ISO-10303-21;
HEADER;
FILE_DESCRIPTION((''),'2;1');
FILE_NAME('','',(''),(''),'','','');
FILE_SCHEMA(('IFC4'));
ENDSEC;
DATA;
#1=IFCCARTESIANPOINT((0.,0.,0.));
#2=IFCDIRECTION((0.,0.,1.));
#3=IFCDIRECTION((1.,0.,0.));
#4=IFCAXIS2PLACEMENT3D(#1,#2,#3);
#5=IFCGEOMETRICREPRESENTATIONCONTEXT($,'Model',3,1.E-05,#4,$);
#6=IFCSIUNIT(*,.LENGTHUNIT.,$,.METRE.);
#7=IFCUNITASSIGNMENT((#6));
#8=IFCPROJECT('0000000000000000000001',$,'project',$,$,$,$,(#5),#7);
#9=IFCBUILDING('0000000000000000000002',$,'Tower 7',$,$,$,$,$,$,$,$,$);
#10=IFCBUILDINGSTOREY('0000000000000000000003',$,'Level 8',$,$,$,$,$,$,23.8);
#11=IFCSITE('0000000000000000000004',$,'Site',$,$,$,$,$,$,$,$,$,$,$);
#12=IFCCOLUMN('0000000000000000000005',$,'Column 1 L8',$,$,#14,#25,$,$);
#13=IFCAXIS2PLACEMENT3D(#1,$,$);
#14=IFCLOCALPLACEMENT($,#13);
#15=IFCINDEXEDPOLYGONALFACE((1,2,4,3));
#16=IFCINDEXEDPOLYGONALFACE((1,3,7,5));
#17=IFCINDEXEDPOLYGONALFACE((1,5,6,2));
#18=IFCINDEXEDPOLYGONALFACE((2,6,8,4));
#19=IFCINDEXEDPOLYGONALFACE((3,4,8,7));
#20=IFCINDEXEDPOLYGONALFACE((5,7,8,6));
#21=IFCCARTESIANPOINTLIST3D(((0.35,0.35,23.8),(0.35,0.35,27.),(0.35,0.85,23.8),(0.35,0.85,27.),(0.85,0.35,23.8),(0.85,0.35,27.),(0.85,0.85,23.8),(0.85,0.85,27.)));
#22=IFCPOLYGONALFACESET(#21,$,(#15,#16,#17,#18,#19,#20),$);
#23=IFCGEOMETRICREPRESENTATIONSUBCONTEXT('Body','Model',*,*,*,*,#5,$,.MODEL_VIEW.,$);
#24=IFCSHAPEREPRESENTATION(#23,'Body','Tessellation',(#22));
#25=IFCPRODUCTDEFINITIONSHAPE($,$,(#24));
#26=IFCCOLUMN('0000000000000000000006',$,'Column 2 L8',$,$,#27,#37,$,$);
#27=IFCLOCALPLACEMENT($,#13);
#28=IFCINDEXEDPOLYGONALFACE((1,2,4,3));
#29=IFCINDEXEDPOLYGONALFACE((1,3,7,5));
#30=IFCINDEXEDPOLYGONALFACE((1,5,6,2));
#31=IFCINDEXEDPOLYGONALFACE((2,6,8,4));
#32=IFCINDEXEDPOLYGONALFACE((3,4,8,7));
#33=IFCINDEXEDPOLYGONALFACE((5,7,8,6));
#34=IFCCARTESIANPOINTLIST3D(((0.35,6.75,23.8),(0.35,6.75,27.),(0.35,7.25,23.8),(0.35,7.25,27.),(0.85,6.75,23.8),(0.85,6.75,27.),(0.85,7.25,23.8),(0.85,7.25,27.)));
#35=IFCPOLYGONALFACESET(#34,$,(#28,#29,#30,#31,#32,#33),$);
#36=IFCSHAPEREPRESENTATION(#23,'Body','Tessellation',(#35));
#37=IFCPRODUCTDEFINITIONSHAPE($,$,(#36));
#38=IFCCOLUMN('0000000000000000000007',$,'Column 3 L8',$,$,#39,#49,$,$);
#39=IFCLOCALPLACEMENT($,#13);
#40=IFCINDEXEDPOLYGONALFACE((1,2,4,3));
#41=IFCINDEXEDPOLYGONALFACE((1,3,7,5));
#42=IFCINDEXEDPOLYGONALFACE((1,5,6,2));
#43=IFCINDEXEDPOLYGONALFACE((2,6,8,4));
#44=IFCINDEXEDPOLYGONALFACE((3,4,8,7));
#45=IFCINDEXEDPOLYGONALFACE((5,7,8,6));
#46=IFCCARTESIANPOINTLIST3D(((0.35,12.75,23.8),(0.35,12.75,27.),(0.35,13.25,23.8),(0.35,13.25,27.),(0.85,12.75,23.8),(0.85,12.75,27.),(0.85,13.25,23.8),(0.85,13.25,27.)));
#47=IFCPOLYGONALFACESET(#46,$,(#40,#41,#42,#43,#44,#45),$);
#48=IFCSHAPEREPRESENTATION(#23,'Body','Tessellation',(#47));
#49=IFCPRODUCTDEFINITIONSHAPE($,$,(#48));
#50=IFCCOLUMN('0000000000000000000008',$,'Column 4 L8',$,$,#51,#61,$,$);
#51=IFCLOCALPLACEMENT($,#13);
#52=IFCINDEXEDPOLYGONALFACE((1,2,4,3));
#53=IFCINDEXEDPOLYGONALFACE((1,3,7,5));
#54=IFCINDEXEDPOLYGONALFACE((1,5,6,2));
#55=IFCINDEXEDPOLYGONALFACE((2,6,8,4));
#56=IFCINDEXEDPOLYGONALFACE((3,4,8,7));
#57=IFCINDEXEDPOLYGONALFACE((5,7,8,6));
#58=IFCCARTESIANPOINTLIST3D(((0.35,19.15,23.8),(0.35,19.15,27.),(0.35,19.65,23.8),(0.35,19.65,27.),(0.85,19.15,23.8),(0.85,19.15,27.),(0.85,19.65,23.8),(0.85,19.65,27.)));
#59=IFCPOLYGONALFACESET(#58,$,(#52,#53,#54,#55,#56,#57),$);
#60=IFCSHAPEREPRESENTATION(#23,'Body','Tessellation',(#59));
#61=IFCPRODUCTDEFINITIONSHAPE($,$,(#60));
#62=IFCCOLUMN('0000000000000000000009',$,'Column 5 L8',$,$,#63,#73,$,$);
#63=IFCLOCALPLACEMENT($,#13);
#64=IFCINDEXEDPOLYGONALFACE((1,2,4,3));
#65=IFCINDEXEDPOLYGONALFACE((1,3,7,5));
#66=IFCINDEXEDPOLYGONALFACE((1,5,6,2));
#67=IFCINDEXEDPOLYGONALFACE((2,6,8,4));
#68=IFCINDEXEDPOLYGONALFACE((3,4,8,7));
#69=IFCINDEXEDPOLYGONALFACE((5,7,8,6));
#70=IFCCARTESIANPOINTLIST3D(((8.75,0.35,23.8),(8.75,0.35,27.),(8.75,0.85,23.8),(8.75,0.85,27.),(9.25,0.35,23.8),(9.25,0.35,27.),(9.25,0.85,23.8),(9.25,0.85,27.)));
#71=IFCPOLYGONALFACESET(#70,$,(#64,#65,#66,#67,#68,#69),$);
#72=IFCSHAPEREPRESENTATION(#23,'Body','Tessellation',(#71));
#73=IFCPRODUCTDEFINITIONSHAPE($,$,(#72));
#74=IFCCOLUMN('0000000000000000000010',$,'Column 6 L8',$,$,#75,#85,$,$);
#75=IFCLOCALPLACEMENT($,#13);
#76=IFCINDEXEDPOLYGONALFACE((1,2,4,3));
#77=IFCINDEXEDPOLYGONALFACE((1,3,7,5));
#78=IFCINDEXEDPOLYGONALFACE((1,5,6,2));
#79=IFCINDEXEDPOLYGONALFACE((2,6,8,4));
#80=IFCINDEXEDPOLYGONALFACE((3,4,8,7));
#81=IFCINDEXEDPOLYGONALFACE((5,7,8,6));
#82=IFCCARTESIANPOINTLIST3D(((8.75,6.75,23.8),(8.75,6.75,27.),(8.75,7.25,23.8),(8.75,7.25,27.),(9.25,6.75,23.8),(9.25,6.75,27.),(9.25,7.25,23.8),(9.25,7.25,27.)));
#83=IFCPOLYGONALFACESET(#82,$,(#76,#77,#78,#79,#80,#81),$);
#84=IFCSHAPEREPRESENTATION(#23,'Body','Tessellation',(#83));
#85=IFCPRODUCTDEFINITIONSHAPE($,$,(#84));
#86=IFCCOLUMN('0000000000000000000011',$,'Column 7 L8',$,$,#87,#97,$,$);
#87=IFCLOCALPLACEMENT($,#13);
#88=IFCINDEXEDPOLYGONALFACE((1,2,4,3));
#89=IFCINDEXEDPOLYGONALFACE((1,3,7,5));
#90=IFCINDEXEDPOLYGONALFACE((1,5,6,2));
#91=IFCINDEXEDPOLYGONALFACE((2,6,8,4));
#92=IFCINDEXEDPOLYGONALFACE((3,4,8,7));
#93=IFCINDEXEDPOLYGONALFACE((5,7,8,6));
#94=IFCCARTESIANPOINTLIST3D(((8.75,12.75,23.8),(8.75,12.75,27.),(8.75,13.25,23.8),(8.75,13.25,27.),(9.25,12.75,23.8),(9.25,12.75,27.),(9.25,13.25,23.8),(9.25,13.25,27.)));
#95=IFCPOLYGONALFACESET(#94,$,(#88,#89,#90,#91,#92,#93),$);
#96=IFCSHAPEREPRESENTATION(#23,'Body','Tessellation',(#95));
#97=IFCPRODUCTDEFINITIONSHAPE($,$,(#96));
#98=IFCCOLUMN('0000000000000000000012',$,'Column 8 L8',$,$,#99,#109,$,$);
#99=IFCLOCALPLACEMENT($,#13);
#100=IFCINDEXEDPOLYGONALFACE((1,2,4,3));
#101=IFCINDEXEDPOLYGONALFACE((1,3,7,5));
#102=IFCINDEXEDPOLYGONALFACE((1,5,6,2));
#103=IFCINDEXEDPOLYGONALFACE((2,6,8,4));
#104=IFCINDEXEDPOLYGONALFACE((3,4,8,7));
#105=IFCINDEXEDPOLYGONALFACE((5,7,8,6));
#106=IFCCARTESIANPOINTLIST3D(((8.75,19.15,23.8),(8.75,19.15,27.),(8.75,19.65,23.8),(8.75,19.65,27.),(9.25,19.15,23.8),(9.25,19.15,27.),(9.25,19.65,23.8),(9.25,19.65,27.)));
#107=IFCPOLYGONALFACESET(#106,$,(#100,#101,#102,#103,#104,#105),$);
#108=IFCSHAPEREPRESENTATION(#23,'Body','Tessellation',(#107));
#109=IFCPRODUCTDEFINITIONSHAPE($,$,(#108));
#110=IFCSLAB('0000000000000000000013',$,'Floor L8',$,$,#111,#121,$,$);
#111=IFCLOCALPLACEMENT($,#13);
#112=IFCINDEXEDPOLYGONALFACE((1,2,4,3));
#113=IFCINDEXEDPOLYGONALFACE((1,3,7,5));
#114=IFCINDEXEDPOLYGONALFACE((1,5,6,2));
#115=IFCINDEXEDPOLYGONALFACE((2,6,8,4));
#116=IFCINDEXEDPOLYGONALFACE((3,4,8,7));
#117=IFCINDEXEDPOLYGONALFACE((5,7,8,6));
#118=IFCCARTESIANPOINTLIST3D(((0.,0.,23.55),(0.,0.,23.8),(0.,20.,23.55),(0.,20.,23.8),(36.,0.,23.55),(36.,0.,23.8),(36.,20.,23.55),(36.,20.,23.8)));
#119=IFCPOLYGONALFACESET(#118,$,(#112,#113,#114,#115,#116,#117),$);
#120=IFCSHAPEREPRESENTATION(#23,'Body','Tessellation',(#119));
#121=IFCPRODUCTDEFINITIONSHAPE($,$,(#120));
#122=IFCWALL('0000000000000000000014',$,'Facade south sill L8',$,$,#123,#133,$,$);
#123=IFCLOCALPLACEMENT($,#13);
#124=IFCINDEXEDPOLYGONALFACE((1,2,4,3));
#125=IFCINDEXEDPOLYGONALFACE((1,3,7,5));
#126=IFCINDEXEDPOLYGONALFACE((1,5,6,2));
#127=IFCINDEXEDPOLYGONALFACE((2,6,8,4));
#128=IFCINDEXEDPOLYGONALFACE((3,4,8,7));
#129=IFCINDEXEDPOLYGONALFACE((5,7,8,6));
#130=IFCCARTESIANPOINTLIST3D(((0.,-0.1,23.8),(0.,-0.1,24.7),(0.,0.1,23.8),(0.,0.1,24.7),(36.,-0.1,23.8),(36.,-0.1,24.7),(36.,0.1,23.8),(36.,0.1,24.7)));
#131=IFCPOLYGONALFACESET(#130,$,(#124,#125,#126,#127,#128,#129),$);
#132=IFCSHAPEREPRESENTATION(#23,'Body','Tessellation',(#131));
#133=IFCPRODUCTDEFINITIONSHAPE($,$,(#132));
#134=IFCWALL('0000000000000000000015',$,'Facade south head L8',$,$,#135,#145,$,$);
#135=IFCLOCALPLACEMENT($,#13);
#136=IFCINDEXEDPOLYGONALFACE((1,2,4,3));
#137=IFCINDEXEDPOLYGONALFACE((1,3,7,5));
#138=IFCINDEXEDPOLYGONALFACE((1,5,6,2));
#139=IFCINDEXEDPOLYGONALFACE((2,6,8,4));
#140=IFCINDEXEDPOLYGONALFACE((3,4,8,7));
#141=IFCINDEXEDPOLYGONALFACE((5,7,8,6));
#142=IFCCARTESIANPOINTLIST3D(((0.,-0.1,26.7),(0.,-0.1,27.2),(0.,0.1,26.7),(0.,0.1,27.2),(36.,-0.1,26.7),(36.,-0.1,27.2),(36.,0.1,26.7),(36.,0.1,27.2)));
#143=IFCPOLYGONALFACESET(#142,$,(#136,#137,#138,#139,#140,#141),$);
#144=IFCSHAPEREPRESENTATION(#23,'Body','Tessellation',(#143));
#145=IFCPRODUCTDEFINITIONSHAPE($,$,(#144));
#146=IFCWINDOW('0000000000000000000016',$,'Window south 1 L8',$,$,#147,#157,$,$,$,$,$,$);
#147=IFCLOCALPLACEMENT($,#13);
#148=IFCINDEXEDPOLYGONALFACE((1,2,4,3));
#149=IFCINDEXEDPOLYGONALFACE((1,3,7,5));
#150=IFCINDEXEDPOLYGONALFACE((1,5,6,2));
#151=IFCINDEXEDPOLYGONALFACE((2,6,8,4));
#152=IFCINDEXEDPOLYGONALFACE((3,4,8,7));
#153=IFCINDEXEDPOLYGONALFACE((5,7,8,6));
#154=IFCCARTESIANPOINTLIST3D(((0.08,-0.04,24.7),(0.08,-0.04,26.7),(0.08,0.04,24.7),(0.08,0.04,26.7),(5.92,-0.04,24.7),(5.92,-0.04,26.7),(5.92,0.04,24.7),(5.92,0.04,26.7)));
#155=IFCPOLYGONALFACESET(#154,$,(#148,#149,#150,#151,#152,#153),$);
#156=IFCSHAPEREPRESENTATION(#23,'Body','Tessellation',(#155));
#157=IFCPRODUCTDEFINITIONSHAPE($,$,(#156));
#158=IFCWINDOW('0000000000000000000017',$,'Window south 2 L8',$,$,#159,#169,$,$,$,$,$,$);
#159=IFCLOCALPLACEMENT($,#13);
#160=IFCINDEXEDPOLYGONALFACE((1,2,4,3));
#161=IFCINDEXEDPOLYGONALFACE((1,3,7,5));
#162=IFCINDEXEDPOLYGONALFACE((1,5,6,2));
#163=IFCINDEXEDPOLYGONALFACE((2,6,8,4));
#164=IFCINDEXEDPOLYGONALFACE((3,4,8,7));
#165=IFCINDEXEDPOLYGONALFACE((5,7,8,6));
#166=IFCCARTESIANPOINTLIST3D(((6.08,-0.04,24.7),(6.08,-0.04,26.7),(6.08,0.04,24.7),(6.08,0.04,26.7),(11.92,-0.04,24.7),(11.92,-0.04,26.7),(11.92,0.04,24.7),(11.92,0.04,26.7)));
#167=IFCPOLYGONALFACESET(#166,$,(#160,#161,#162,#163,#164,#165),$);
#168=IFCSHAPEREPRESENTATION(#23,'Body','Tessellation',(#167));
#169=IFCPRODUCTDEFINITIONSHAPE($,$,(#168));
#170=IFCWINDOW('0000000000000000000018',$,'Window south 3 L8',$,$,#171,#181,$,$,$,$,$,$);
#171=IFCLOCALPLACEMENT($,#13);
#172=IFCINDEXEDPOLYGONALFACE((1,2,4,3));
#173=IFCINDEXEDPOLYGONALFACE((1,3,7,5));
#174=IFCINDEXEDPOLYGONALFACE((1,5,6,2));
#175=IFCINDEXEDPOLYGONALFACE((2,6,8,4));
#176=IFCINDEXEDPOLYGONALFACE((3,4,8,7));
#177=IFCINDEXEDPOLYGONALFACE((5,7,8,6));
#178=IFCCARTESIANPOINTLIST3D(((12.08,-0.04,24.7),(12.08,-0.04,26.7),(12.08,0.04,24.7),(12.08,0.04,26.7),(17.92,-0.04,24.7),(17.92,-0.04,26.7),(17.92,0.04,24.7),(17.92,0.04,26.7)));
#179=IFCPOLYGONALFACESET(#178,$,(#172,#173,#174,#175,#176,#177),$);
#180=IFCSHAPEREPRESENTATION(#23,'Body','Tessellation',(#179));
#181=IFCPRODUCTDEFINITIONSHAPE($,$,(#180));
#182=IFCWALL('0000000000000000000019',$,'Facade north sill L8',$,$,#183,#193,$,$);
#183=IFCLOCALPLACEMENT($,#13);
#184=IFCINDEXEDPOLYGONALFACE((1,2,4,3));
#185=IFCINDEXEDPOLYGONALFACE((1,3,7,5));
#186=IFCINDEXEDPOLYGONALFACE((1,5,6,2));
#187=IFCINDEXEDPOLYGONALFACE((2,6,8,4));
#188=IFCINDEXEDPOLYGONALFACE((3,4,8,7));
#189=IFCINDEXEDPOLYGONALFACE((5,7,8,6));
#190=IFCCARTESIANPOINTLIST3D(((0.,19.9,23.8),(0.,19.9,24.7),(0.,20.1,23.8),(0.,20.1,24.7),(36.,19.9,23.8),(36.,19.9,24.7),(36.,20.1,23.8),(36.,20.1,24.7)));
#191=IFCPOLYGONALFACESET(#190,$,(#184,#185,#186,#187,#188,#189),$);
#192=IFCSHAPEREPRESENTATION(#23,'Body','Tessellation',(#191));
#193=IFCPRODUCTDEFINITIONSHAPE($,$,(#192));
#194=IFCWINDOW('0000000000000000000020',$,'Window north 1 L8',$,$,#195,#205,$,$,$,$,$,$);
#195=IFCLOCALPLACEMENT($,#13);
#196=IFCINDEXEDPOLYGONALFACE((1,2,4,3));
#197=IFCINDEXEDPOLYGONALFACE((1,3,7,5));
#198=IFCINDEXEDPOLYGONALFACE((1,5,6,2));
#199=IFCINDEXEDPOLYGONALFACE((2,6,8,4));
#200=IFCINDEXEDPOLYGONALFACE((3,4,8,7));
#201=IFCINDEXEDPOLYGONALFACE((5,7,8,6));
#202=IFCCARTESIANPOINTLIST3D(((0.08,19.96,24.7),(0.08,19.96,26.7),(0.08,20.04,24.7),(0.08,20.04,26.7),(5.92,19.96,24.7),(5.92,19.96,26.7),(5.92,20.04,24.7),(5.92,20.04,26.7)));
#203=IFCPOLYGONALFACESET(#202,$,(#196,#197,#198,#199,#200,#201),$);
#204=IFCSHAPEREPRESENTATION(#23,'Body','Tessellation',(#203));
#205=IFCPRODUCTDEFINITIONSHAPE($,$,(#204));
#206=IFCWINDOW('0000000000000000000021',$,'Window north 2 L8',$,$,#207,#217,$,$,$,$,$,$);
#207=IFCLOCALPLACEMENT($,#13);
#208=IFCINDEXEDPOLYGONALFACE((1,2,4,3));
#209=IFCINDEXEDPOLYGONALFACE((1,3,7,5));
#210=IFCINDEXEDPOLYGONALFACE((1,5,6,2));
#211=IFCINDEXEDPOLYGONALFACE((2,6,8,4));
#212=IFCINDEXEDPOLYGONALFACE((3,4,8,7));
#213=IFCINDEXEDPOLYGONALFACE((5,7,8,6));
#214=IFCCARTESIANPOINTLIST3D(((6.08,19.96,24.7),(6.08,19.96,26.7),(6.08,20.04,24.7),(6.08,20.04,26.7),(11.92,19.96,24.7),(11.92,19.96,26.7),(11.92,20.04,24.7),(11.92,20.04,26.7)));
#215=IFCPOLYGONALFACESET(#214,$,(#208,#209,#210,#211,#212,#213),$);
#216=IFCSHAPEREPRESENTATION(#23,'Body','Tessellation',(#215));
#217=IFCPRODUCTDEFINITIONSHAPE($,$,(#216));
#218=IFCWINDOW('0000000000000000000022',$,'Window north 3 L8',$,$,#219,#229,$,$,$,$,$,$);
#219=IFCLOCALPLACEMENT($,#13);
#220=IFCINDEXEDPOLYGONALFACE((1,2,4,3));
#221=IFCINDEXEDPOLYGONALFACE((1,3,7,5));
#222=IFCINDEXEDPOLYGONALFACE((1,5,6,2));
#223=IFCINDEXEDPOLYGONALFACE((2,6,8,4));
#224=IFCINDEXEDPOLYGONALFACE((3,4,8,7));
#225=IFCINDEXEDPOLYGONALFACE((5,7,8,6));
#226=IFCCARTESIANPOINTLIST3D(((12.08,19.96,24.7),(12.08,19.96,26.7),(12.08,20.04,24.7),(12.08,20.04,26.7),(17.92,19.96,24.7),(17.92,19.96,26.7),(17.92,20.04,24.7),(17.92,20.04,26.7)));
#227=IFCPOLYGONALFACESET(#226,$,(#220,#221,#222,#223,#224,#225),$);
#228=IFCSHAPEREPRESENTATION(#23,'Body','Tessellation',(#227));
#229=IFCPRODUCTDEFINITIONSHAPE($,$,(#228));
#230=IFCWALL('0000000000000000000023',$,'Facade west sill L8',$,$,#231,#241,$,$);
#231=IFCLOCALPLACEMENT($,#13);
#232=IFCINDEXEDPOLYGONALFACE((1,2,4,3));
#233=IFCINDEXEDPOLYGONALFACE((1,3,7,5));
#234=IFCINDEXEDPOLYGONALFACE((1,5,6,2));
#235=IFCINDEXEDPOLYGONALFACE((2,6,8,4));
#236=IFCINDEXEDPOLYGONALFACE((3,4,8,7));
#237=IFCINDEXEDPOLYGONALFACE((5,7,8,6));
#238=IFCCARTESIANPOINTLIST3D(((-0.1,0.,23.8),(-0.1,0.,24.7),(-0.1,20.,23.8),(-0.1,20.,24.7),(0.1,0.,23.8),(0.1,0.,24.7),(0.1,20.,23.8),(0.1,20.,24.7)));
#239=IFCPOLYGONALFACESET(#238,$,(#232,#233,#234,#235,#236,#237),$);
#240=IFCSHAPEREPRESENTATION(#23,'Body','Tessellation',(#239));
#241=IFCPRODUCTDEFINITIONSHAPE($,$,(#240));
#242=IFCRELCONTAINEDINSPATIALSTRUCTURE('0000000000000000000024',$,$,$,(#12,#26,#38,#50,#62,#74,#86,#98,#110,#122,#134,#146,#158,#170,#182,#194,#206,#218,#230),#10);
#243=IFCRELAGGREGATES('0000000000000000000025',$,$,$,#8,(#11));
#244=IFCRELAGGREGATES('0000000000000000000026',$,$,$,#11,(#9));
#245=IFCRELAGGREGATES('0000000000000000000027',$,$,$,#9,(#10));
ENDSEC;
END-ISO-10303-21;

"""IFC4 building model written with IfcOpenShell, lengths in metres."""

from ifc_helpers import new_model, si_unit, frame, origin, origin_with_axes, origin_2d, place, context, subcontext, project, spatial, rectangle, extrude, element, save


model = new_model("IFC4")

# Units and contexts
model_context = context("Model", 3, precision=1e-05, world=origin_with_axes())
body_context = subcontext(model_context, "Body", "Model", "MODEL_VIEW")
ifc_project = project(units=[si_unit("LENGTHUNIT", "METRE")], contexts=[model_context])

# Site, building, storey
site = spatial("IfcSite", under=ifc_project, Name="Site")
building = spatial("IfcBuilding", under=site, Name="Tower 7")
storey = spatial("IfcBuildingStorey", under=building, Name="Level 8", Elevation=23.8)

# Columns
for number, where, z_axis, x_axis, name in (
    (1, (0.6, 0.6, 23.8), (0.0, 0.0, 1.0), (1.0, 0.0, 0.0), "Column 1 L8"),
    (2, (0.6, 7.0, 23.8), (0.0, 0.0, 1.0), (1.0, 0.0, 0.0), "Column 2 L8"),
    (3, (0.6, 13.0, 23.8), (0.0, 0.0, 1.0), (1.0, 0.0, 0.0), "Column 3 L8"),
    (4, (0.6, 19.4, 23.8), (0.0, 0.0, 1.0), (1.0, 0.0, 0.0), "Column 4 L8"),
    (5, (9.0, 0.6, 23.8), (0.0, 0.0, 1.0), (1.0, 0.0, 0.0), "Column 5 L8"),
    (6, (9.0, 7.0, 23.8), (0.0, 0.0, 1.0), (1.0, 0.0, 0.0), "Column 6 L8"),
    (7, (9.0, 13.0, 23.8), (0.0, 0.0, 1.0), (1.0, 0.0, 0.0), "Column 7 L8"),
    (8, (9.0, 19.4, 23.8), (0.0, 0.0, 1.0), (1.0, 0.0, 0.0), "Column 8 L8"),
):
    element("IfcColumn", number, at=place(None, frame(where, z_axis=z_axis, x_axis=x_axis)), inside=storey, Name=name, context=body_context, shape_type="SweptSolid", body=[
        extrude(rectangle(XDim=0.5, YDim=0.5, at=origin_2d()), origin(), (0.0, 0.0, 1.0), 3.2),
    ])

# Slab
slab_placement = place(None, frame((18.0, 10.0, 23.55), z_axis=(0.0, 0.0, 1.0), x_axis=(1.0, 0.0, 0.0)))
element("IfcSlab", 9, at=slab_placement, inside=storey, Name="Floor L8", context=body_context, shape_type="SweptSolid", body=[
    extrude(rectangle(XDim=36.0, YDim=20.0, at=origin_2d()), origin(), (0.0, 0.0, 1.0), 0.25),
])

# Walls
wall_1_placement = place(None, frame((18.0, 0.0, 23.8), z_axis=(0.0, 0.0, 1.0), x_axis=(1.0, 0.0, 0.0)))
element("IfcWall", 10, at=wall_1_placement, inside=storey, Name="Facade south sill L8", context=body_context, shape_type="SweptSolid", body=[
    extrude(rectangle(XDim=36.0, YDim=0.2, at=origin_2d()), origin(), (0.0, 0.0, 1.0), 0.9),
])
wall_2_placement = place(None, frame((18.0, 0.0, 26.7), z_axis=(0.0, 0.0, 1.0), x_axis=(1.0, 0.0, 0.0)))
element("IfcWall", 11, at=wall_2_placement, inside=storey, Name="Facade south head L8", context=body_context, shape_type="SweptSolid", body=[
    extrude(rectangle(XDim=36.0, YDim=0.2, at=origin_2d()), origin(), (0.0, 0.0, 1.0), 0.5),
])

# Windows
for number, where, z_axis, x_axis, name in (
    (12, (3.0, 0.0, 24.7), (0.0, 0.0, 1.0), (1.0, 0.0, 0.0), "Window south 1 L8"),
    (13, (9.0, 0.0, 24.7), (0.0, 0.0, 1.0), (1.0, 0.0, 0.0), "Window south 2 L8"),
):
    element("IfcWindow", number, at=place(None, frame(where, z_axis=z_axis, x_axis=x_axis)), inside=storey, Name=name, context=body_context, shape_type="SweptSolid", body=[
        extrude(rectangle(XDim=5.84, YDim=0.08, at=origin_2d()), origin(), (0.0, 0.0, 1.0), 2.0),
    ])
window_1_placement = place(None, frame((15.0, 0.0, 24.7), z_axis=(0.0, 0.0, 1.0), x_axis=(1.0, 0.0, 0.0)))
element("IfcWindow", 14, at=window_1_placement, inside=storey, Name="Window south 3 L8", context=body_context, shape_type="SweptSolid", body=[
    extrude(rectangle(XDim=5.84, YDim=0.08, at=origin_2d()), origin(), (0.0, 0.0, 1.0), 2.0),
])

# Wall
wall_3_placement = place(None, frame((18.0, 20.0, 23.8), z_axis=(0.0, 0.0, 1.0), x_axis=(1.0, 0.0, 0.0)))
element("IfcWall", 15, at=wall_3_placement, inside=storey, Name="Facade north sill L8", context=body_context, shape_type="SweptSolid", body=[
    extrude(rectangle(XDim=36.0, YDim=0.2, at=origin_2d()), origin(), (0.0, 0.0, 1.0), 0.9),
])

# Windows
for number, where, z_axis, x_axis, name in (
    (16, (3.0, 20.0, 24.7), (0.0, 0.0, 1.0), (1.0, 0.0, 0.0), "Window north 1 L8"),
    (17, (9.0, 20.0, 24.7), (0.0, 0.0, 1.0), (1.0, 0.0, 0.0), "Window north 2 L8"),
):
    element("IfcWindow", number, at=place(None, frame(where, z_axis=z_axis, x_axis=x_axis)), inside=storey, Name=name, context=body_context, shape_type="SweptSolid", body=[
        extrude(rectangle(XDim=5.84, YDim=0.08, at=origin_2d()), origin(), (0.0, 0.0, 1.0), 2.0),
    ])
window_2_placement = place(None, frame((15.0, 20.0, 24.7), z_axis=(0.0, 0.0, 1.0), x_axis=(1.0, 0.0, 0.0)))
element("IfcWindow", 18, at=window_2_placement, inside=storey, Name="Window north 3 L8", context=body_context, shape_type="SweptSolid", body=[
    extrude(rectangle(XDim=5.84, YDim=0.08, at=origin_2d()), origin(), (0.0, 0.0, 1.0), 2.0),
])

# Wall
wall_4_placement = place(None, frame((0.0, 10.0, 23.8), z_axis=(0.0, 0.0, 1.0), x_axis=(1.0, 0.0, 0.0)))
element("IfcWall", 19, at=wall_4_placement, inside=storey, Name="Facade west sill L8", context=body_context, shape_type="SweptSolid", body=[
    extrude(rectangle(XDim=0.2, YDim=20.0, at=origin_2d()), origin(), (0.0, 0.0, 1.0), 0.9),
])

save(model, "model.ifc")
